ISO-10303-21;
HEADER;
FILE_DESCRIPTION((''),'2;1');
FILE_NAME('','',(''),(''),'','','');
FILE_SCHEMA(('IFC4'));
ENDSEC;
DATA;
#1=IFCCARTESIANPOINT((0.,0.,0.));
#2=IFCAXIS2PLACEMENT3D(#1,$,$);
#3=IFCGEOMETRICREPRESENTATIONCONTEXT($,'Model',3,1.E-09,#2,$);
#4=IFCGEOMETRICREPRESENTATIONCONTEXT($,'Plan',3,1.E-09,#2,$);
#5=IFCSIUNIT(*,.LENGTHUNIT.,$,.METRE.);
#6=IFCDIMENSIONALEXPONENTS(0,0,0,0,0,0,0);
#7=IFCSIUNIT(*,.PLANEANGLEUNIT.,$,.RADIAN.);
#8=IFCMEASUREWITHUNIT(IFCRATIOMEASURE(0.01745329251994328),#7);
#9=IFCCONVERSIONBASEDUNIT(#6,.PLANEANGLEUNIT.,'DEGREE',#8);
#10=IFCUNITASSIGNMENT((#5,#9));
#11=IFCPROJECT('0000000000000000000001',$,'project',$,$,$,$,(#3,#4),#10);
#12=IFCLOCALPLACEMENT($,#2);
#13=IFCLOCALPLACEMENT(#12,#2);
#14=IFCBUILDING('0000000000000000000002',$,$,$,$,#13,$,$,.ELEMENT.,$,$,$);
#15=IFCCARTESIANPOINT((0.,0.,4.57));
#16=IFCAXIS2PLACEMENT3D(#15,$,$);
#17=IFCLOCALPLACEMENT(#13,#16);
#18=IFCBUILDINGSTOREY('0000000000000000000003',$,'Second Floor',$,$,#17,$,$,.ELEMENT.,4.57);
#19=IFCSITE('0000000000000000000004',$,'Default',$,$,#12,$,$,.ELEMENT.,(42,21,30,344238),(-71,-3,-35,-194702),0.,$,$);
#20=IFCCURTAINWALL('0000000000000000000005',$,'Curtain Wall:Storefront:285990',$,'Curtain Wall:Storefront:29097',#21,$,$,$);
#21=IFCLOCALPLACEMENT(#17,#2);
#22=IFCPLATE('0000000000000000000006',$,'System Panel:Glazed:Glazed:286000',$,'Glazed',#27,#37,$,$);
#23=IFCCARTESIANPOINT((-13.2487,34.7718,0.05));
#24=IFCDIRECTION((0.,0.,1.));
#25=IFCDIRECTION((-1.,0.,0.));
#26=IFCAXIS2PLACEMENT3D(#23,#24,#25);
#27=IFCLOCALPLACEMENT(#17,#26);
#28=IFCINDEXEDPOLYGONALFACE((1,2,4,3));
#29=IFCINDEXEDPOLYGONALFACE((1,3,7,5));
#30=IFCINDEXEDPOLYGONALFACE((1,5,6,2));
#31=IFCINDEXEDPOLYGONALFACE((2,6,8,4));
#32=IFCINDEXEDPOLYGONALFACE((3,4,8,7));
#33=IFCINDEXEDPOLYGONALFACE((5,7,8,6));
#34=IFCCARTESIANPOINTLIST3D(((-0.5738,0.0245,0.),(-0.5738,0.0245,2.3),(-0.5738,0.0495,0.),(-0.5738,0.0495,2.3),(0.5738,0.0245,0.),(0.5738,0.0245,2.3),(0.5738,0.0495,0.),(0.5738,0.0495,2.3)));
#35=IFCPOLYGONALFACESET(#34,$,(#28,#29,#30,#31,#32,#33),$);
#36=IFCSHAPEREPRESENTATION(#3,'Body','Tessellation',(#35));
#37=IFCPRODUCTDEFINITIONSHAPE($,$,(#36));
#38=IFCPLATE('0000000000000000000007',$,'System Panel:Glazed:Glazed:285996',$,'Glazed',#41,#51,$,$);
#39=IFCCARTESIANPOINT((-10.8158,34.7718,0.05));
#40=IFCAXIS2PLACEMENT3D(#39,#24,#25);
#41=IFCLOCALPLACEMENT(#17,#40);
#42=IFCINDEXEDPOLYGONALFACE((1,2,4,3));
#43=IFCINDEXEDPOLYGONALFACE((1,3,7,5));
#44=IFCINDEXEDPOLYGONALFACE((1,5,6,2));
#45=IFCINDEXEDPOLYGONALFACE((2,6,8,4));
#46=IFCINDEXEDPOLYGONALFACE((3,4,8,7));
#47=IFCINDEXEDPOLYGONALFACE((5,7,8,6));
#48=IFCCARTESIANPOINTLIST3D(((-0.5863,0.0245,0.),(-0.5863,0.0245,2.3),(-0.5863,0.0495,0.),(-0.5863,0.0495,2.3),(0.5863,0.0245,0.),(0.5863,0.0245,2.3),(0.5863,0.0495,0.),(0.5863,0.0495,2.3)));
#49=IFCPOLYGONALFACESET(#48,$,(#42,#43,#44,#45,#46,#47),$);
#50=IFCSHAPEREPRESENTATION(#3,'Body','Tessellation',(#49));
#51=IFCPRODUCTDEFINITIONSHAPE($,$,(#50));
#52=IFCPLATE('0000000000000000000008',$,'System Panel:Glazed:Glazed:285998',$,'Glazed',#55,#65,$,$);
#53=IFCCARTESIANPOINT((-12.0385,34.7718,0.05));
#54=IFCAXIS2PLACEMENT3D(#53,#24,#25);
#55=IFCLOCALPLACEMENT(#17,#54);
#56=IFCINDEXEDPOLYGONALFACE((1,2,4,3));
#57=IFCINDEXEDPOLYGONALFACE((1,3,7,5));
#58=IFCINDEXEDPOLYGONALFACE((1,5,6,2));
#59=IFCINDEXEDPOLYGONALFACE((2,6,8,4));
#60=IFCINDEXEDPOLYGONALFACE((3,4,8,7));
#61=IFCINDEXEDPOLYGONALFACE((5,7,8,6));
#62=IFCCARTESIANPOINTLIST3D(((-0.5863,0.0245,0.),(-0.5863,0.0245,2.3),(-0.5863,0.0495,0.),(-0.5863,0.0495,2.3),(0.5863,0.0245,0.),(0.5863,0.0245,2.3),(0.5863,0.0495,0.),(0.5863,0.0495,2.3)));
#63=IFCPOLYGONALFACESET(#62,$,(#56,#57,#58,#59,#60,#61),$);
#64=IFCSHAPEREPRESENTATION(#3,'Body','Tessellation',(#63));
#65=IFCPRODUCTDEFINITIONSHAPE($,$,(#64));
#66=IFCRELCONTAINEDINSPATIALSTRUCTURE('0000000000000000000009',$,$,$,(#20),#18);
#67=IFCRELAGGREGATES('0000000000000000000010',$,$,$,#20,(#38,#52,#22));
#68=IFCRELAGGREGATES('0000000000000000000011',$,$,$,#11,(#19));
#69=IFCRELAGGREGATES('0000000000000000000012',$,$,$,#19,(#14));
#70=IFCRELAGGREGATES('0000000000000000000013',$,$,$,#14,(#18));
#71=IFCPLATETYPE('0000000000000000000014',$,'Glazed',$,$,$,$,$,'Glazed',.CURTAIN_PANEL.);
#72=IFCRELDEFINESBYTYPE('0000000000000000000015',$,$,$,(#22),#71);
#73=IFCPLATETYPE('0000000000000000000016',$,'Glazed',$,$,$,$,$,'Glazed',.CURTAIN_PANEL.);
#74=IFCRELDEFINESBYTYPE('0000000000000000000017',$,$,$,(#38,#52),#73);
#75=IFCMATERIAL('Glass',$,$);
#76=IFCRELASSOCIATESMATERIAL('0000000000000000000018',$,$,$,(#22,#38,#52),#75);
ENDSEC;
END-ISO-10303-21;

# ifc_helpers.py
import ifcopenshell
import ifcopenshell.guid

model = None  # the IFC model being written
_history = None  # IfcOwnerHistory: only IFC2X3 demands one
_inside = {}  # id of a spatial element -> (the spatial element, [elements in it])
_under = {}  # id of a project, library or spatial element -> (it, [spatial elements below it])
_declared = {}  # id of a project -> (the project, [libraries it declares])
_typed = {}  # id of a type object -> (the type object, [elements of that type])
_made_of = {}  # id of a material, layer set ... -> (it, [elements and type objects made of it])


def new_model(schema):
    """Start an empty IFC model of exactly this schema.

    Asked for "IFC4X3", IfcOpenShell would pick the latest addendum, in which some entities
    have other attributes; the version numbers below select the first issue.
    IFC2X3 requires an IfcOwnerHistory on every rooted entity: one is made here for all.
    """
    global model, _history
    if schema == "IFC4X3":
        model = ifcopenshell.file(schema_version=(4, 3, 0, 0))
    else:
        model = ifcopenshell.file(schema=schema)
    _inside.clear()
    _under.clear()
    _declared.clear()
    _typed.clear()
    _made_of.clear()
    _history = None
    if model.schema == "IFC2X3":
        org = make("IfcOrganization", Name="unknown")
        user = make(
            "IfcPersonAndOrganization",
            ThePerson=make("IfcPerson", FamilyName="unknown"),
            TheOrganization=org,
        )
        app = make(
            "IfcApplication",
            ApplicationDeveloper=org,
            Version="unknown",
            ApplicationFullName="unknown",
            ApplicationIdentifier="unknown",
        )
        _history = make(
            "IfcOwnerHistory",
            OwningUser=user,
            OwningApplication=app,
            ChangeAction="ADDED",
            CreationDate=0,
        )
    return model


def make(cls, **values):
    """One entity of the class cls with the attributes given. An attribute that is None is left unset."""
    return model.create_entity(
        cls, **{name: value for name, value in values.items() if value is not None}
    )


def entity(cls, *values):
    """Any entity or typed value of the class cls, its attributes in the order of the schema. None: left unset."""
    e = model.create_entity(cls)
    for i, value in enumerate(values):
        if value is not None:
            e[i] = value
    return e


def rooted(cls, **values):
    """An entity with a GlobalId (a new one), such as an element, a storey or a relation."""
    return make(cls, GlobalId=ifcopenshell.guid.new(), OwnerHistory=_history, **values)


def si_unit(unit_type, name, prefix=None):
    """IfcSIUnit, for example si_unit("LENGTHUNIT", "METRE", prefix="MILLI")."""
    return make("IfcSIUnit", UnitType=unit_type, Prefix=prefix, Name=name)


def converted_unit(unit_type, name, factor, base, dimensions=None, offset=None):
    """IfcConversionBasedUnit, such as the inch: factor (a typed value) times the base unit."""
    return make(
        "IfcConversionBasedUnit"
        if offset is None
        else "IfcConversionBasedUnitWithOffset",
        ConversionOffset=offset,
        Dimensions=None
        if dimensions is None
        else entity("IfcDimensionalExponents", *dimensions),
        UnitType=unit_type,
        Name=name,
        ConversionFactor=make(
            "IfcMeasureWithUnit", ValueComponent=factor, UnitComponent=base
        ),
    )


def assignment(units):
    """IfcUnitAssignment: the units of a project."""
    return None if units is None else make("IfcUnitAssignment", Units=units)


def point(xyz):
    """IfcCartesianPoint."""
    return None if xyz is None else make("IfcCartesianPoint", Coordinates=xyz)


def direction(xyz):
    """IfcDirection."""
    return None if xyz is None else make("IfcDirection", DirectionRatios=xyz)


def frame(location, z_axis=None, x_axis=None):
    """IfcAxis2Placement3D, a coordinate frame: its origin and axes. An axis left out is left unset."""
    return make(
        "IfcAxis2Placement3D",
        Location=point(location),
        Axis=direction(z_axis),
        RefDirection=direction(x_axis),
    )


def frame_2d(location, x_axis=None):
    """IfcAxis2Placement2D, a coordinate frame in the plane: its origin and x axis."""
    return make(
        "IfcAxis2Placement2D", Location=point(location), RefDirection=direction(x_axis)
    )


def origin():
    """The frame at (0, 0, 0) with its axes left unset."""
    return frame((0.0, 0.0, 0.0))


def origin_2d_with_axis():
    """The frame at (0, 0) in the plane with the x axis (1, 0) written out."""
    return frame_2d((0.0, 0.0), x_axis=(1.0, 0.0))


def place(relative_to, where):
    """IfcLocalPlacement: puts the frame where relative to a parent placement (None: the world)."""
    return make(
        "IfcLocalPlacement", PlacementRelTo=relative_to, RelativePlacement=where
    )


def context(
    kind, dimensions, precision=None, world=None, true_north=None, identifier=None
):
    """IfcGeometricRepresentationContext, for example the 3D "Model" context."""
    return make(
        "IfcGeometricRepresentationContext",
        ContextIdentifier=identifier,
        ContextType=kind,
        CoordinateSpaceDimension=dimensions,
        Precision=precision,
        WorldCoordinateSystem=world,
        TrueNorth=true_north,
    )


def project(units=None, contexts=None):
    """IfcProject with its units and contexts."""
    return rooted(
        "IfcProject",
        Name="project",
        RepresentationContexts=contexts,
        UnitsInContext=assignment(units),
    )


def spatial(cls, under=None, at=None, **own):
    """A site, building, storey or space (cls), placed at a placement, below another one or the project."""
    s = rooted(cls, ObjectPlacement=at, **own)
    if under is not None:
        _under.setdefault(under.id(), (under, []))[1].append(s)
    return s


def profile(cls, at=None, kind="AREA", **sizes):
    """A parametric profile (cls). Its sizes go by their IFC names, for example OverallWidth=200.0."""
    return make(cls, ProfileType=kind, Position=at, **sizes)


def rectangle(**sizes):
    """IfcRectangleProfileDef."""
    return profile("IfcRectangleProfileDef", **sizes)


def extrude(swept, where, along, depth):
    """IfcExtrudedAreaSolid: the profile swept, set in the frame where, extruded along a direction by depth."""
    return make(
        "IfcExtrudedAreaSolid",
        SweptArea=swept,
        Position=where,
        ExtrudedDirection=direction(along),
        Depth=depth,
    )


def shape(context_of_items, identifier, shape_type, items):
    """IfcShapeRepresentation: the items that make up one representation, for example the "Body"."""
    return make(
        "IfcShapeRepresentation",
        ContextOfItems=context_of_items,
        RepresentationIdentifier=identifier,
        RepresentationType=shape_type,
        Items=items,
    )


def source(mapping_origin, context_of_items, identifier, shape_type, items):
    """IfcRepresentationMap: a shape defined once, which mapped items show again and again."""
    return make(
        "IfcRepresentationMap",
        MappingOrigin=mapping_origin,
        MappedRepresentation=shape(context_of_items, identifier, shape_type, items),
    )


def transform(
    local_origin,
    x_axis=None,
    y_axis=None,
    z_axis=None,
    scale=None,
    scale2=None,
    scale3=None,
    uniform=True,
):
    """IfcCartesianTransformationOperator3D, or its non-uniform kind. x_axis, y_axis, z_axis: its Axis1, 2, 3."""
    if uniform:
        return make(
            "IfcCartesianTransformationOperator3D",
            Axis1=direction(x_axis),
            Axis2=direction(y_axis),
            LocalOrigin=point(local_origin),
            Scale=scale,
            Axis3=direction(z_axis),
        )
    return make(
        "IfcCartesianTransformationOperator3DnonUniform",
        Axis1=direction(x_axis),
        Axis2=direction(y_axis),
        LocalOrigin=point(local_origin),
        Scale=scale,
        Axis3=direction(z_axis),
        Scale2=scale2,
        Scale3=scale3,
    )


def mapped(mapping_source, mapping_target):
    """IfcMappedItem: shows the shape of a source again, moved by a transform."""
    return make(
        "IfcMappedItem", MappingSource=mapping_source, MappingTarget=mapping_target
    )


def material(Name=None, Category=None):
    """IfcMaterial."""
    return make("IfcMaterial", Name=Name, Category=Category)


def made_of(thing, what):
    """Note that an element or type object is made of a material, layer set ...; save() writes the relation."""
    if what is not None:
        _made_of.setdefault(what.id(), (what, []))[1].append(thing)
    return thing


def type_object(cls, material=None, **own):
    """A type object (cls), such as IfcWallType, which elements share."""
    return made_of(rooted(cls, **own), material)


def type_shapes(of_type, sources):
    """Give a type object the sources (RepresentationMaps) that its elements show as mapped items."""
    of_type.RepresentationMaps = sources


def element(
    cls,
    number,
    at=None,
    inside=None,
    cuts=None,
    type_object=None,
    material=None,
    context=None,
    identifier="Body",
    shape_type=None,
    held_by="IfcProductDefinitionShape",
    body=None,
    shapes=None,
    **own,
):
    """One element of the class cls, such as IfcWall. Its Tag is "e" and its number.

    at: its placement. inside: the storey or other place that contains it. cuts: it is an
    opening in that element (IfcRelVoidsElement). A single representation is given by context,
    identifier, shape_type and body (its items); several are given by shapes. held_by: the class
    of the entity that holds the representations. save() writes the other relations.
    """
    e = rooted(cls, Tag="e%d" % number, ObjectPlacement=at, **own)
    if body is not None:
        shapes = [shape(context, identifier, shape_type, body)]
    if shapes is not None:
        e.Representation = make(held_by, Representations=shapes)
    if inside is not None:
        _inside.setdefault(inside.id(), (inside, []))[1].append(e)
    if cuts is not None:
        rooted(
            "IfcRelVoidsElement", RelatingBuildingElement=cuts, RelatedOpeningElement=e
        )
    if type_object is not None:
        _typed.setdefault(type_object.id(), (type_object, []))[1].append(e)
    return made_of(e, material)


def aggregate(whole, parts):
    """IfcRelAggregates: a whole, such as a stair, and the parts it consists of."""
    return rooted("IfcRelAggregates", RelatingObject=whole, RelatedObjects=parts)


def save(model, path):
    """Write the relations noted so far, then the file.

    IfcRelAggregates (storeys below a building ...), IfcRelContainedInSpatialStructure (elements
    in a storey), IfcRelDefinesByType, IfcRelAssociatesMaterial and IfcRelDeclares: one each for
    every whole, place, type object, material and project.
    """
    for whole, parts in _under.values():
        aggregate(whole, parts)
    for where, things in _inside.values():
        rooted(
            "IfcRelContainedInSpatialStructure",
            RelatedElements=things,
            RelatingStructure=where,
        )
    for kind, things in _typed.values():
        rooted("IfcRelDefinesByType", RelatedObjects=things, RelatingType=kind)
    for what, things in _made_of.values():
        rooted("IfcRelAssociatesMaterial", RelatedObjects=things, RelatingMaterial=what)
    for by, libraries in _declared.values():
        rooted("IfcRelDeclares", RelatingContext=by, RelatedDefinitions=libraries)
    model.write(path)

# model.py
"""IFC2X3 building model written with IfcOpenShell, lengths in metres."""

from ifc_helpers import new_model, entity, si_unit, converted_unit, frame, origin, origin_2d_with_axis, place, context, project, spatial, rectangle, extrude, source, transform, mapped, material, type_object, type_shapes, element, aggregate, save


model = new_model("IFC2X3")

# Units and contexts
model_context = context("Model", 3, precision=1e-09, world=origin())
plan_context = context("Plan", 3, precision=1e-09, world=origin())
ifc_project = project(units=[si_unit("LENGTHUNIT", "METRE"), converted_unit("PLANEANGLEUNIT", "DEGREE", entity("IfcRatioMeasure", 0.01745329251994328), si_unit("PLANEANGLEUNIT", "RADIAN"), dimensions=[0, 0, 0, 0, 0, 0, 0])], contexts=[model_context, plan_context])

# Site, building, storey
site_placement = place(None, origin())
site = spatial("IfcSite", under=ifc_project, at=site_placement, Name="Default", CompositionType="ELEMENT", RefLatitude=(42, 21, 30, 344238), RefLongitude=(-71, -3, -35, -194702), RefElevation=0.0)
building_placement = place(site_placement, origin())
building = spatial("IfcBuilding", under=site, at=building_placement, CompositionType="ELEMENT")
storey_placement = place(building_placement, frame((0.0, 0.0, 4.57)))
storey = spatial("IfcBuildingStorey", under=building, at=storey_placement, Name="Second Floor", CompositionType="ELEMENT", Elevation=4.57)

# Curtain wall, plates
curtain_wall_placement = place(storey_placement, origin())
curtain_wall = element("IfcCurtainWall", 1, at=curtain_wall_placement, inside=storey, Name="Curtain Wall:Storefront:285990", ObjectType="Curtain Wall:Storefront:29097")
ifc_material_1 = material(Name="Glass")
plate_type_1 = type_object("IfcPlateType", Name="Glazed", ElementType="Glazed", PredefinedType="CURTAIN_PANEL")
shared_shape_1 = source(origin(), model_context, "Body", "SweptSolid", [
    extrude(rectangle(XDim=0.025, YDim=1.1477, at=origin_2d_with_axis()), frame((0.0, 0.037, 0.0), z_axis=(0.0, 0.0, 1.0), x_axis=(0.0, 1.0, 0.0)), (0.0, 0.0, 1.0), 2.3),
])
type_shapes(plate_type_1, [shared_shape_1])
plate_1_placement = place(storey_placement, frame((-13.2487, 34.7718, 0.05), z_axis=(0.0, 0.0, 1.0), x_axis=(-1.0, 0.0, 0.0)))
plate_1 = element("IfcPlate", 2, at=plate_1_placement, type_object=plate_type_1, material=ifc_material_1, Name="System Panel:Glazed:Glazed:286000", ObjectType="Glazed", context=model_context, shape_type="MappedRepresentation", body=[
    mapped(shared_shape_1, transform((0.0, 0.0, 0.0), scale=1.0)),
])
plate_type_2 = type_object("IfcPlateType", Name="Glazed", ElementType="Glazed", PredefinedType="CURTAIN_PANEL")
shared_shape_2 = source(origin(), model_context, "Body", "SweptSolid", [
    extrude(rectangle(XDim=0.025, YDim=1.1727, at=origin_2d_with_axis()), frame((0.0, 0.037, 0.0), z_axis=(0.0, 0.0, 1.0), x_axis=(0.0, 1.0, 0.0)), (0.0, 0.0, 1.0), 2.3),
])
type_shapes(plate_type_2, [shared_shape_2])
plate_2_placement = place(storey_placement, frame((-10.8158, 34.7718, 0.05), z_axis=(0.0, 0.0, 1.0), x_axis=(-1.0, 0.0, 0.0)))
plate_2 = element("IfcPlate", 3, at=plate_2_placement, type_object=plate_type_2, material=ifc_material_1, Name="System Panel:Glazed:Glazed:285996", ObjectType="Glazed", context=model_context, shape_type="MappedRepresentation", body=[
    mapped(shared_shape_2, transform((0.0, 0.0, 0.0), scale=1.0)),
])
plate_3_placement = place(storey_placement, frame((-12.0385, 34.7718, 0.05), z_axis=(0.0, 0.0, 1.0), x_axis=(-1.0, 0.0, 0.0)))
plate_3 = element("IfcPlate", 4, at=plate_3_placement, type_object=plate_type_2, material=ifc_material_1, Name="System Panel:Glazed:Glazed:285998", ObjectType="Glazed", context=model_context, shape_type="MappedRepresentation", body=[
    mapped(shared_shape_2, transform((0.0, 0.0, 0.0), scale=1.0)),
])
aggregate(curtain_wall, [plate_2, plate_3, plate_1])

save(model, "model.ifc")
